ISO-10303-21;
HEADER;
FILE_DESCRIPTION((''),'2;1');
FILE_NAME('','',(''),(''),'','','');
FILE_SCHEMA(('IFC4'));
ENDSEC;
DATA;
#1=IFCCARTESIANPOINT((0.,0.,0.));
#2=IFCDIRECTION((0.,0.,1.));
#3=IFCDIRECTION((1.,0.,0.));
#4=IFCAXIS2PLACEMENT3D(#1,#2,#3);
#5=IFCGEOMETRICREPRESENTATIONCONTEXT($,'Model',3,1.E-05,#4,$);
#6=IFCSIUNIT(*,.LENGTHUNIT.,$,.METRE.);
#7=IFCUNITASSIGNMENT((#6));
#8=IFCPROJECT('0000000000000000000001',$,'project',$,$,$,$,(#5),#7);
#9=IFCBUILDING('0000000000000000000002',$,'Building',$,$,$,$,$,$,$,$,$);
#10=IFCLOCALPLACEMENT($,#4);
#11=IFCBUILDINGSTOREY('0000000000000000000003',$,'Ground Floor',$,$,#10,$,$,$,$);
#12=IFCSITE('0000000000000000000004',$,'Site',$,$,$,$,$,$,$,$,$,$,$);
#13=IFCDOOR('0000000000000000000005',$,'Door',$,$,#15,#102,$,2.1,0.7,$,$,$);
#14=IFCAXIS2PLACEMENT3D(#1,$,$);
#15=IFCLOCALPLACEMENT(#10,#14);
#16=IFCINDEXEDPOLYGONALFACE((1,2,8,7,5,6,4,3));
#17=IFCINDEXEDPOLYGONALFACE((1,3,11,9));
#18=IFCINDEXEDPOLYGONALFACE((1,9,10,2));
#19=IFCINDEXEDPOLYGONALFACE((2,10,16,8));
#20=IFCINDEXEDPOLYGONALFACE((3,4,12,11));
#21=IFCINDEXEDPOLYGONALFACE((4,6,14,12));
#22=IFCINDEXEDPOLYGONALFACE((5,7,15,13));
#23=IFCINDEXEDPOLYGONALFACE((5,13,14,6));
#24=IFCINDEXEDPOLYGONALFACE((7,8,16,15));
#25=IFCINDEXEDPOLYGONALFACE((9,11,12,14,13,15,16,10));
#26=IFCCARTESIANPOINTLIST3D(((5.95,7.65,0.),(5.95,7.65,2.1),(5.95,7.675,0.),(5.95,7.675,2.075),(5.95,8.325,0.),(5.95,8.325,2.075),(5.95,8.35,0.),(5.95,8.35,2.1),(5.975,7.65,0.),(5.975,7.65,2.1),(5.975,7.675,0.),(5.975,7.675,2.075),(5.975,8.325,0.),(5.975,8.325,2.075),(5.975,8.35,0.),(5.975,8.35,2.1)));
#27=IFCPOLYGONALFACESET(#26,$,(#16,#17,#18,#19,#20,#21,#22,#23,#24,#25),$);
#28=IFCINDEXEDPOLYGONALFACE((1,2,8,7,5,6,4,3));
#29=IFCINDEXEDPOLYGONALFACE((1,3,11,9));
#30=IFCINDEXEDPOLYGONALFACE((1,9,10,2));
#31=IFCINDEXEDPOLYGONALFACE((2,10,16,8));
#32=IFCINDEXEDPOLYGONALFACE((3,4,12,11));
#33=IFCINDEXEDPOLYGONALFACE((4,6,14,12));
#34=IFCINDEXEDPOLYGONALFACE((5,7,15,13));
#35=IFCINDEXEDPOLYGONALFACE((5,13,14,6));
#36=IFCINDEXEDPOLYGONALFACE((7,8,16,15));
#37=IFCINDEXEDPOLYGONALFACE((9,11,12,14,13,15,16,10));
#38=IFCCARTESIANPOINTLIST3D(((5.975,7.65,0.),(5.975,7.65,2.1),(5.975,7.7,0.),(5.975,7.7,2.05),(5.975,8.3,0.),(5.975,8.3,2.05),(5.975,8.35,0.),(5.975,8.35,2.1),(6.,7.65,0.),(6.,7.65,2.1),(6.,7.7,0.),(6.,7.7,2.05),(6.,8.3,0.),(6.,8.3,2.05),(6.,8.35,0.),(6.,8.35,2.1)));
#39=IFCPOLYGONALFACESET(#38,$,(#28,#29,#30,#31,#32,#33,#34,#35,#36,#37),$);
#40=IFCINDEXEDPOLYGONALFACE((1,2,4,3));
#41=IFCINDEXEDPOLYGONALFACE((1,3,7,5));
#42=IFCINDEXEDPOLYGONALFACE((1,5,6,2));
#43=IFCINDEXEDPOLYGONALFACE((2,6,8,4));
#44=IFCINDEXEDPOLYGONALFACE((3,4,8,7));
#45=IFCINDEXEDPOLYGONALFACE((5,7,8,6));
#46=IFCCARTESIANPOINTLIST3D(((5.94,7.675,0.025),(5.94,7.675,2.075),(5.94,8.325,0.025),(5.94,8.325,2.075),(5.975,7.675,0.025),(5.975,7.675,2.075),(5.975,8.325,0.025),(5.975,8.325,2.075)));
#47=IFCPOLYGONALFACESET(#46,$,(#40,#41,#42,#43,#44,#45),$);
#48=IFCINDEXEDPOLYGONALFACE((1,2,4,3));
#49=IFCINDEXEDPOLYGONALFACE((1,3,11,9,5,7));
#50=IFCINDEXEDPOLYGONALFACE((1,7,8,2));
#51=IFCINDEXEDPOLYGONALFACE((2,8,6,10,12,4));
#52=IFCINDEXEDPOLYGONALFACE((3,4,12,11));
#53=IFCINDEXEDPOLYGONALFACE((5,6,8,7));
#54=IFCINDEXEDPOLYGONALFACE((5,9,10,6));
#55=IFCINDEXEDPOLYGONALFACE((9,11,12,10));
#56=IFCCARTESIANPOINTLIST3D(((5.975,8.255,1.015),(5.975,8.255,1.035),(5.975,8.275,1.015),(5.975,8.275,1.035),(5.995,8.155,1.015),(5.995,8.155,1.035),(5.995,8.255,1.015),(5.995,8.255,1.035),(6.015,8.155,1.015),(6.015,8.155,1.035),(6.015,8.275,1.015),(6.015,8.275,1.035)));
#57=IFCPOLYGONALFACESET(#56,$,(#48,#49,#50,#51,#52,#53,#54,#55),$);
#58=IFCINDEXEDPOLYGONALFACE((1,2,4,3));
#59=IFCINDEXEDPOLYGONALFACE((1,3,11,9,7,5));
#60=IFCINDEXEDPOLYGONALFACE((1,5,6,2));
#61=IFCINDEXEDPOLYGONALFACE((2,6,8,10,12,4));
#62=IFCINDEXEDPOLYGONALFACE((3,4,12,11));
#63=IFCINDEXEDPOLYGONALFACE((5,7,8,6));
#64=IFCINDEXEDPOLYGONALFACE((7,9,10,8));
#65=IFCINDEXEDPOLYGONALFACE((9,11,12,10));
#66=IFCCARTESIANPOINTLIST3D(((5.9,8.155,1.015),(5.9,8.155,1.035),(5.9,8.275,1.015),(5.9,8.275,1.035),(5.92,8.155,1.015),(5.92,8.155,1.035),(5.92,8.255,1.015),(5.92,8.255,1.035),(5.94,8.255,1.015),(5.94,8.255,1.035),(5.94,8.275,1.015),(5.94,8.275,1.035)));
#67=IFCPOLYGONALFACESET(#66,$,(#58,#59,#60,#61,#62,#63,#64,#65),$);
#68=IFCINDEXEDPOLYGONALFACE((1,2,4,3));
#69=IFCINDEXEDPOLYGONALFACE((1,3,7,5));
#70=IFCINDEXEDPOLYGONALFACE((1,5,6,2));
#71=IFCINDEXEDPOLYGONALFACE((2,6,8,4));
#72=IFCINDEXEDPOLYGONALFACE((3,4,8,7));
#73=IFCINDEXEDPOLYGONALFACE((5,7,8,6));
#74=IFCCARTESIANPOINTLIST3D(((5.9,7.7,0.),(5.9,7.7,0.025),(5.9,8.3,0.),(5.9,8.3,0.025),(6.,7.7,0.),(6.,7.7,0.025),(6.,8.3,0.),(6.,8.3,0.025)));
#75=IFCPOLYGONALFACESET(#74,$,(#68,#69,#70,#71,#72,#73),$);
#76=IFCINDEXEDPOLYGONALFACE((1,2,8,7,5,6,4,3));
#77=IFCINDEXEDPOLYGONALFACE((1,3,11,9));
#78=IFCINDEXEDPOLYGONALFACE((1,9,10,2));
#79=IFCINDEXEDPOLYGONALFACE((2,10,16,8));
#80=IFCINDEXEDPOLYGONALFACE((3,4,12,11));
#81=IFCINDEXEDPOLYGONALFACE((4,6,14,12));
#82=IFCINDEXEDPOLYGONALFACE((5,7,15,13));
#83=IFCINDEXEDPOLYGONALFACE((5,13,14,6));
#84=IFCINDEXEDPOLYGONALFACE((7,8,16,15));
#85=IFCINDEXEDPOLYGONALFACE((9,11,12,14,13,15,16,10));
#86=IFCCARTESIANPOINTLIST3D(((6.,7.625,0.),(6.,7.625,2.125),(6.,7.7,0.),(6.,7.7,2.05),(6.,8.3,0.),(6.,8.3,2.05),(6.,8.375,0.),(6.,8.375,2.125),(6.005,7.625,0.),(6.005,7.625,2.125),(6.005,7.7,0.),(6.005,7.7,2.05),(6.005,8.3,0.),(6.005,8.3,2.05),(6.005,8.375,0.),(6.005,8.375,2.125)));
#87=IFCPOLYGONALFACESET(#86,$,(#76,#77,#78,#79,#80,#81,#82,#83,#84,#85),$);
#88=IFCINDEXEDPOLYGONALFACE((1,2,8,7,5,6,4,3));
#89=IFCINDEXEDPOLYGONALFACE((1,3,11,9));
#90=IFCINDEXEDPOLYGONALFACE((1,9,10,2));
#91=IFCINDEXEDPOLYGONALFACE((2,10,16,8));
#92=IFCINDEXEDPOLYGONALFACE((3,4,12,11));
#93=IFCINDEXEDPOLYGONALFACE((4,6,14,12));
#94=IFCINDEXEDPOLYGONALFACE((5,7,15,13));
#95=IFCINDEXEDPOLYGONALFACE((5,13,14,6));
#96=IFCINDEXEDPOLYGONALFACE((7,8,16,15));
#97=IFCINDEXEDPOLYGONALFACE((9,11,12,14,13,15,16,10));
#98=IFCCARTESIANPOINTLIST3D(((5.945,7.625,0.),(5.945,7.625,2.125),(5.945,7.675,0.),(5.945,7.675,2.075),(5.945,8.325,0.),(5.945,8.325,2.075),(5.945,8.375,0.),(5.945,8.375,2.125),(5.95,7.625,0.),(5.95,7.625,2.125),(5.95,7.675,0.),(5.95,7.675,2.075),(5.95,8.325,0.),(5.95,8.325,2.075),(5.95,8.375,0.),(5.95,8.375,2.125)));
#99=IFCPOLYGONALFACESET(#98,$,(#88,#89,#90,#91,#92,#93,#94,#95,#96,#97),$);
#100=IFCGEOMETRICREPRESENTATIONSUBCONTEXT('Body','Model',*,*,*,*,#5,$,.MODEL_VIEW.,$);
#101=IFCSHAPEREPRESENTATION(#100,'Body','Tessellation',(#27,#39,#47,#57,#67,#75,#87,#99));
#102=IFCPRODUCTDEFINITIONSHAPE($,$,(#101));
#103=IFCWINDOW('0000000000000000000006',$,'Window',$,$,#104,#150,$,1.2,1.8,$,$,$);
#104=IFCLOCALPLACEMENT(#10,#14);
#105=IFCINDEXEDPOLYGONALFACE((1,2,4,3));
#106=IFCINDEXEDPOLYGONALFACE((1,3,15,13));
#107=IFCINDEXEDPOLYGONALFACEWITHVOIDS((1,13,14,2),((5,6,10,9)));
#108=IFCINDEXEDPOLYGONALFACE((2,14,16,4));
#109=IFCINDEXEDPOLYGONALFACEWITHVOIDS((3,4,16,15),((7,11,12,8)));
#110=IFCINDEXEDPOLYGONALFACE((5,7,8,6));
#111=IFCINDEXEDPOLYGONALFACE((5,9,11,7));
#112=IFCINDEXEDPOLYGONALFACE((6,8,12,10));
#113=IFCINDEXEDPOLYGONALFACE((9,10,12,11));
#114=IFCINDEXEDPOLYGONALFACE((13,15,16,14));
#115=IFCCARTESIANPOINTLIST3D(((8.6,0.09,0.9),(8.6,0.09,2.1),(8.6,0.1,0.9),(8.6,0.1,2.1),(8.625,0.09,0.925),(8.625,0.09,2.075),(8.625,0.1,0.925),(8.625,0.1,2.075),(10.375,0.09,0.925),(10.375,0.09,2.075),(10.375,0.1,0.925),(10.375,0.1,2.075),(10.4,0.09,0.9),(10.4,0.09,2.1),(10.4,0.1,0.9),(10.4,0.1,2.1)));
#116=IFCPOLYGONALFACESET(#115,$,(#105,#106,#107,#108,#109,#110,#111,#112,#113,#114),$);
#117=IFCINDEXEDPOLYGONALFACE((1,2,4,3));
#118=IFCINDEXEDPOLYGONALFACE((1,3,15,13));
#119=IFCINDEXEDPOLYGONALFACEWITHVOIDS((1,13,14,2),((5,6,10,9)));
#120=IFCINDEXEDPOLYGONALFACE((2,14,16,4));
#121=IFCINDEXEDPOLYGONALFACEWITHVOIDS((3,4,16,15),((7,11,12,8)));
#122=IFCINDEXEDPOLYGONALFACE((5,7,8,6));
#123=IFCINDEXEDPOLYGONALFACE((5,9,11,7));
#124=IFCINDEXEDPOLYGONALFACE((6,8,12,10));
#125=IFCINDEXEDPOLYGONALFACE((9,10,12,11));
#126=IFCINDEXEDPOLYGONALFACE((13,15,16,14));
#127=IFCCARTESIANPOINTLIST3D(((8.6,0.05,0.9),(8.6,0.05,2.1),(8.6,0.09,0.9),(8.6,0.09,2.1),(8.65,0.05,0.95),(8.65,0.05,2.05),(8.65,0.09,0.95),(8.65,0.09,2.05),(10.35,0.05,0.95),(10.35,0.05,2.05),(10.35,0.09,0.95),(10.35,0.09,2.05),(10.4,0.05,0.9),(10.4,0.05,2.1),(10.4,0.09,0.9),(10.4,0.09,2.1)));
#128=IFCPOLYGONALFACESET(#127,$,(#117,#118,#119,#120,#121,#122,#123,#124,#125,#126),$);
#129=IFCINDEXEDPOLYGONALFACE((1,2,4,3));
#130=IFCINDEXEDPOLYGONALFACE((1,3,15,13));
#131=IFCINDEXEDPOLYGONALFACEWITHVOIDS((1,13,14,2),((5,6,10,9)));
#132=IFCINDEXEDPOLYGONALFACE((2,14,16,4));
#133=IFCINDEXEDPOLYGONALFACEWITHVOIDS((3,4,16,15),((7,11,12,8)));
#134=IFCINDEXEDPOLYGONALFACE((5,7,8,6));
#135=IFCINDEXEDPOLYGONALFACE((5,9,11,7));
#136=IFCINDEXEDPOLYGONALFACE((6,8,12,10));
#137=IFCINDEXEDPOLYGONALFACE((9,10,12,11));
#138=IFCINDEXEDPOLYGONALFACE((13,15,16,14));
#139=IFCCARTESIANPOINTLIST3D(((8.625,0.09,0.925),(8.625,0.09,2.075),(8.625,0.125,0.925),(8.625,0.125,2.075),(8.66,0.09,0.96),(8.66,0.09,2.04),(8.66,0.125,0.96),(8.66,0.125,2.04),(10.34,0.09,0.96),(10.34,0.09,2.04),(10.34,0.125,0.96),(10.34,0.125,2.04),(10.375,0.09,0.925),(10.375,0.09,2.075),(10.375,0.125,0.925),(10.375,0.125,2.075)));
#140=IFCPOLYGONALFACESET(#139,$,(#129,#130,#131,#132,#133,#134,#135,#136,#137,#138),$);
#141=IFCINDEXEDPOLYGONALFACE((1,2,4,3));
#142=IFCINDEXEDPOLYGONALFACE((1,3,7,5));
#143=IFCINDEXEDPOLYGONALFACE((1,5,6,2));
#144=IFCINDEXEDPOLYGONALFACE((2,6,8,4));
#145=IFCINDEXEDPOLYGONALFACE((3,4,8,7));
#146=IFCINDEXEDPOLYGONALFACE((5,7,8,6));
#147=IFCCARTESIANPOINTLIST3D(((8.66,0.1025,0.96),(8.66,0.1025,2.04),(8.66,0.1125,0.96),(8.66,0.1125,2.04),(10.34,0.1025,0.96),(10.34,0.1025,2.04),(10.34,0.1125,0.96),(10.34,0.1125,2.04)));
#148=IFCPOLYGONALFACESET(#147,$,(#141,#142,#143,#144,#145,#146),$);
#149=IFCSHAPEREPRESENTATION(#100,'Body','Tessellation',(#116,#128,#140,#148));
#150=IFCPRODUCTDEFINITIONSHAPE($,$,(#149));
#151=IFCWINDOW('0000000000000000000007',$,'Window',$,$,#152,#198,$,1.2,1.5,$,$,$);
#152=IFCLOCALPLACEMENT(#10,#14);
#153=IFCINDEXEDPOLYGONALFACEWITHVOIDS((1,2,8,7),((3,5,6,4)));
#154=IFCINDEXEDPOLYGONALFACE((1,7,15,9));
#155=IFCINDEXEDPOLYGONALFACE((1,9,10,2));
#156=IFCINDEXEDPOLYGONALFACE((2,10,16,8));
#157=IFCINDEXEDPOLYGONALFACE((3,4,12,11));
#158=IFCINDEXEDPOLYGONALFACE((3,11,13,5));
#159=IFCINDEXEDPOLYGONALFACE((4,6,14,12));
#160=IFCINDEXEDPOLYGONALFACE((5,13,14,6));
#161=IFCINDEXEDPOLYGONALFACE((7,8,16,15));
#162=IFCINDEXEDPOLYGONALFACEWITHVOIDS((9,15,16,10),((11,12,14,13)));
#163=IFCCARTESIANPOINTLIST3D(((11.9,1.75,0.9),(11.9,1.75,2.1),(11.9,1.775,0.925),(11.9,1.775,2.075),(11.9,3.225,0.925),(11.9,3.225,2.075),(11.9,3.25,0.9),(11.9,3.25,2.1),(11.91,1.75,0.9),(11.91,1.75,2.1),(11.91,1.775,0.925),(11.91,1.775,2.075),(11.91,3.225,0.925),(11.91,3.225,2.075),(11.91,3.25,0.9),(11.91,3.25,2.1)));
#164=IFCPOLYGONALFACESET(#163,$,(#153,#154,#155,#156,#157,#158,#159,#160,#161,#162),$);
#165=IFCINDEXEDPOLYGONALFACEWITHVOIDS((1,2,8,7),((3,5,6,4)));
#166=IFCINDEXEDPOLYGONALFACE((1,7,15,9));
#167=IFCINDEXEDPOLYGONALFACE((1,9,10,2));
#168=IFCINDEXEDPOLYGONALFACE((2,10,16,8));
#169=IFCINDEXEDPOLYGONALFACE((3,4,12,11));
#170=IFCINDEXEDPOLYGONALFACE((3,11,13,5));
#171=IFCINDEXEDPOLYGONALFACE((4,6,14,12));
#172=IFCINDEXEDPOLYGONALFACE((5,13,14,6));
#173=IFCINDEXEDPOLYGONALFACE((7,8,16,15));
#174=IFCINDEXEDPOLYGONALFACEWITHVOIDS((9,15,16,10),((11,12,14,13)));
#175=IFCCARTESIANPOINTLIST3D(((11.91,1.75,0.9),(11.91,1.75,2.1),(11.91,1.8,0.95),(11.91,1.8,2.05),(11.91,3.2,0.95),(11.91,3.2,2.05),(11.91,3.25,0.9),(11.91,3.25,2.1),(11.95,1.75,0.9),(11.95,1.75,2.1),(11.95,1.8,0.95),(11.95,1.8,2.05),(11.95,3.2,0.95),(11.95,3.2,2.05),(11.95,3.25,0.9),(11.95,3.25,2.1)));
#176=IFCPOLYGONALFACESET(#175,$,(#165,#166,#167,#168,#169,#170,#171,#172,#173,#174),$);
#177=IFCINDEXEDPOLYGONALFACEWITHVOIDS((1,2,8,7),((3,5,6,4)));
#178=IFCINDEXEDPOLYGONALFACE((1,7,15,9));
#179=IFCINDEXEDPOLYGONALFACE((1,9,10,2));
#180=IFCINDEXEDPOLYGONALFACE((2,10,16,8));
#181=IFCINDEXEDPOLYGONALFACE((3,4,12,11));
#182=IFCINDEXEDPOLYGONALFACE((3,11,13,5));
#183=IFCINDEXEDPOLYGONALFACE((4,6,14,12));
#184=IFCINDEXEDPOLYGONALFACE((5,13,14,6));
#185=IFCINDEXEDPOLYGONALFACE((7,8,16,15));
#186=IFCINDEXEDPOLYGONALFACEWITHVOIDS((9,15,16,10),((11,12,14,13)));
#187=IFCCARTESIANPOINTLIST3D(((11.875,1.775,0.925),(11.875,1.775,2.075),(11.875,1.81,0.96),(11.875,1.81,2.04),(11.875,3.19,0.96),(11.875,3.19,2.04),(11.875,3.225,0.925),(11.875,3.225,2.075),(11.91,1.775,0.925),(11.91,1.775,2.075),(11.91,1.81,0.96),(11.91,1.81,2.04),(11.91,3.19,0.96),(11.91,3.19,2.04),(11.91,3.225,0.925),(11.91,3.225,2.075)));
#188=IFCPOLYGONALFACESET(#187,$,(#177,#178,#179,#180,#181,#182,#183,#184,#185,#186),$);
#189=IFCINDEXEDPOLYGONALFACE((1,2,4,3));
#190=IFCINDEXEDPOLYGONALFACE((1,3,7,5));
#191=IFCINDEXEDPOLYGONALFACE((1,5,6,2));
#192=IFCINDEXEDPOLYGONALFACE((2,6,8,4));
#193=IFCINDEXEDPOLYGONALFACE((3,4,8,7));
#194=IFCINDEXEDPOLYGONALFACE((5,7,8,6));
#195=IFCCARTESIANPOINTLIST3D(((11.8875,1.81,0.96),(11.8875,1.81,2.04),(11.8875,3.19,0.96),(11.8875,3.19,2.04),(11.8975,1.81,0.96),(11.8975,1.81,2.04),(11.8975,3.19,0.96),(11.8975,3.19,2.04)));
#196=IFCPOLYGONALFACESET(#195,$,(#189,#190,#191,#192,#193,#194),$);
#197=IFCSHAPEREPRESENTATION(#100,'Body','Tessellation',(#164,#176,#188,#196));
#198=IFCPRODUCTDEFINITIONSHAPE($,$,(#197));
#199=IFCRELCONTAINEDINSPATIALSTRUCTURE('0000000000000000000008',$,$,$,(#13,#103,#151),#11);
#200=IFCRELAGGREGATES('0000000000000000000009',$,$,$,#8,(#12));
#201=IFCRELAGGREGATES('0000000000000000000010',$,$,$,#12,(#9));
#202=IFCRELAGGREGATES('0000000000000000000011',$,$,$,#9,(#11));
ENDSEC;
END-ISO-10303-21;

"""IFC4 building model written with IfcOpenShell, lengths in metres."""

from ifc_helpers import new_model, si_unit, frame, origin_with_axes, place, context, subcontext, project, spatial, line, indexed_curve, outline, extrude, element, save


model = new_model("IFC4")

# Units and contexts
model_context = context("Model", 3, precision=1e-05, world=origin_with_axes())
body_context = subcontext(model_context, "Body", "Model", "MODEL_VIEW")
ifc_project = project(units=[si_unit("LENGTHUNIT", "METRE")], contexts=[model_context])

# Site, building, storey
site = spatial("IfcSite", under=ifc_project, Name="Site")
building = spatial("IfcBuilding", under=site, Name="Building")
storey_placement = place(None, origin_with_axes())
storey = spatial("IfcBuildingStorey", under=building, at=storey_placement, Name="Ground Floor")

# Door
door_1_placement = place(storey_placement, frame((6.0, 7.65, 0.0), z_axis=(0.0, 0.0, 1.0), x_axis=(0.0, 1.0, 0.0)))
element("IfcDoor", 1, at=door_1_placement, inside=storey, Name="Door", OverallHeight=2.1, OverallWidth=0.7, context=body_context, shape_type="SweptSolid", body=[
    extrude(outline(indexed_curve([(0.0, 0.0), (0.0, 2.1), (0.7, 2.1), (0.7, 0.0), (0.675, 0.0), (0.675, 2.075), (0.025, 2.075), (0.025, 0.0)], segments=[line(1, 2, 3, 4, 5, 6, 7, 8, 1)])), frame((0.0, 0.025, 0.0), z_axis=(0.0, -1.0, 0.0), x_axis=(1.0, 0.0, 0.0)), (0.0, 0.0, -1.0), 0.025),
    extrude(outline(indexed_curve([(0.0, 0.0), (0.0, 2.1), (0.7, 2.1), (0.7, 0.0), (0.65, 0.0), (0.65, 2.05), (0.05, 2.05), (0.05, 0.0)], segments=[line(1, 2, 3, 4, 5, 6, 7, 8, 1)])), frame((0.0, 0.0, 0.0), z_axis=(0.0, -1.0, 0.0), x_axis=(1.0, 0.0, 0.0)), (0.0, 0.0, -1.0), 0.025),
    extrude(outline(indexed_curve([(0.0, 0.0), (0.65, 0.0), (0.65, 0.035), (0.0, 0.035)], segments=[line(1, 2, 3, 4, 1)])), frame((0.025, 0.025, 0.025), z_axis=(0.0, 0.0, 1.0), x_axis=(1.0, 0.0, 0.0)), (0.0, 0.0, 1.0), 2.05),
    extrude(outline(indexed_curve([(0.0, 0.0), (0.0, -0.04), (-0.12, -0.04), (-0.12, -0.02), (-0.02, -0.02), (-0.02, 0.0)], segments=[line(1, 2, 3, 4, 5, 6, 1)])), frame((0.625, 0.025, 1.015), z_axis=(0.0, 0.0, 1.0), x_axis=(1.0, 0.0, 0.0)), (0.0, 0.0, 1.0), 0.02),
    extrude(outline(indexed_curve([(0.0, 0.0), (0.0, 0.04), (-0.12, 0.04), (-0.12, 0.02), (-0.02, 0.02), (-0.02, 0.0)], segments=[line(1, 2, 3, 4, 5, 6, 1)])), frame((0.625, 0.06, 1.015), z_axis=(0.0, 0.0, 1.0), x_axis=(1.0, 0.0, 0.0)), (0.0, 0.0, 1.0), 0.02),
    extrude(outline(indexed_curve([(0.0, 0.0), (0.6, 0.0), (0.6, 0.1), (0.0, 0.1)], segments=[line(1, 2, 3, 4, 1)])), frame((0.05, 0.0, 0.0), z_axis=(0.0, 0.0, 1.0), x_axis=(1.0, 0.0, 0.0)), (0.0, 0.0, 1.0), 0.025),
    extrude(outline(indexed_curve([(0.0, 0.0), (0.0, 2.125), (0.75, 2.125), (0.75, 0.0), (0.675, 0.0), (0.675, 2.05), (0.075, 2.05), (0.075, 0.0)], segments=[line(1, 2, 3, 4, 5, 6, 7, 8, 1)])), frame((-0.025, -0.005, 0.0), z_axis=(0.0, -1.0, 0.0), x_axis=(1.0, 0.0, 0.0)), (0.0, 0.0, -1.0), 0.005),
    extrude(outline(indexed_curve([(0.0, 0.0), (0.0, 2.125), (0.75, 2.125), (0.75, 0.0), (0.7, 0.0), (0.7, 2.075), (0.05, 2.075), (0.05, 0.0)], segments=[line(1, 2, 3, 4, 5, 6, 7, 8, 1)])), frame((-0.025, 0.05, 0.0), z_axis=(0.0, -1.0, 0.0), x_axis=(1.0, 0.0, 0.0)), (0.0, 0.0, -1.0), 0.005),
])

# Windows
window_placement = place(storey_placement, frame((8.6, 0.0, 0.9), z_axis=(0.0, 0.0, 1.0), x_axis=(1.0, 0.0, 0.0)))
element("IfcWindow", 2, at=window_placement, inside=storey, Name="Window", OverallHeight=1.2, OverallWidth=1.8, context=body_context, shape_type="SweptSolid", body=[
    extrude(outline(indexed_curve([(0.0, 0.0), (1.8, 0.0), (1.8, 1.2), (0.0, 1.2)], segments=[line(1, 2, 3, 4, 1)]), holes=[indexed_curve([(0.025, 0.025), (1.775, 0.025), (1.775, 1.175), (0.025, 1.175)], segments=[line(1, 2, 3, 4, 1)])]), frame((0.0, 0.09, 0.0), z_axis=(0.0, -1.0, 0.0), x_axis=(1.0, 0.0, 0.0)), (0.0, 0.0, -1.0), 0.01),
    extrude(outline(indexed_curve([(0.0, 0.0), (1.8, 0.0), (1.8, 1.2), (0.0, 1.2)], segments=[line(1, 2, 3, 4, 1)]), holes=[indexed_curve([(0.05, 0.05), (1.75, 0.05), (1.75, 1.15), (0.05, 1.15)], segments=[line(1, 2, 3, 4, 1)])]), frame((0.0, 0.05, 0.0), z_axis=(0.0, -1.0, 0.0), x_axis=(1.0, 0.0, 0.0)), (0.0, 0.0, -1.0), 0.04),
    extrude(outline(indexed_curve([(0.0, 0.0), (1.75, 0.0), (1.75, 1.15), (0.0, 1.15)], segments=[line(1, 2, 3, 4, 1)]), holes=[indexed_curve([(0.035, 0.035), (1.715, 0.035), (1.715, 1.115), (0.035, 1.115)], segments=[line(1, 2, 3, 4, 1)])]), frame((0.025, 0.09, 0.025), z_axis=(0.0, -1.0, 0.0), x_axis=(1.0, 0.0, 0.0)), (0.0, 0.0, -1.0), 0.035),
    extrude(outline(indexed_curve([(0.035, 0.035), (1.715, 0.035), (1.715, 1.115), (0.035, 1.115)], segments=[line(1, 2, 3, 4, 1)])), frame((0.025, 0.1025, 0.025), z_axis=(0.0, -1.0, 0.0), x_axis=(1.0, 0.0, 0.0)), (0.0, 0.0, -1.0), 0.01),
])
for number, where, z_axis, x_axis, name in (
    (3, (12.0, 1.75, 0.9), (0.0, 0.0, 1.0), (0.0, 1.0, 0.0), "Window"),
):
    element("IfcWindow", number, at=place(storey_placement, frame(where, z_axis=z_axis, x_axis=x_axis)), inside=storey, Name=name, OverallHeight=1.2, OverallWidth=1.5, context=body_context, shape_type="SweptSolid", body=[
        extrude(outline(indexed_curve([(0.0, 0.0), (1.5, 0.0), (1.5, 1.2), (0.0, 1.2)], segments=[line(1, 2, 3, 4, 1)]), holes=[indexed_curve([(0.025, 0.025), (1.475, 0.025), (1.475, 1.175), (0.025, 1.175)], segments=[line(1, 2, 3, 4, 1)])]), frame((0.0, 0.09, 0.0), z_axis=(0.0, -1.0, 0.0), x_axis=(1.0, 0.0, 0.0)), (0.0, 0.0, -1.0), 0.01),
        extrude(outline(indexed_curve([(0.0, 0.0), (1.5, 0.0), (1.5, 1.2), (0.0, 1.2)], segments=[line(1, 2, 3, 4, 1)]), holes=[indexed_curve([(0.05, 0.05), (1.45, 0.05), (1.45, 1.15), (0.05, 1.15)], segments=[line(1, 2, 3, 4, 1)])]), frame((0.0, 0.05, 0.0), z_axis=(0.0, -1.0, 0.0), x_axis=(1.0, 0.0, 0.0)), (0.0, 0.0, -1.0), 0.04),
        extrude(outline(indexed_curve([(0.0, 0.0), (1.45, 0.0), (1.45, 1.15), (0.0, 1.15)], segments=[line(1, 2, 3, 4, 1)]), holes=[indexed_curve([(0.035, 0.035), (1.415, 0.035), (1.415, 1.115), (0.035, 1.115)], segments=[line(1, 2, 3, 4, 1)])]), frame((0.025, 0.09, 0.025), z_axis=(0.0, -1.0, 0.0), x_axis=(1.0, 0.0, 0.0)), (0.0, 0.0, -1.0), 0.035),
        extrude(outline(indexed_curve([(0.035, 0.035), (1.415, 0.035), (1.415, 1.115), (0.035, 1.115)], segments=[line(1, 2, 3, 4, 1)])), frame((0.025, 0.1025, 0.025), z_axis=(0.0, -1.0, 0.0), x_axis=(1.0, 0.0, 0.0)), (0.0, 0.0, -1.0), 0.01),
    ])

save(model, "model.ifc")
